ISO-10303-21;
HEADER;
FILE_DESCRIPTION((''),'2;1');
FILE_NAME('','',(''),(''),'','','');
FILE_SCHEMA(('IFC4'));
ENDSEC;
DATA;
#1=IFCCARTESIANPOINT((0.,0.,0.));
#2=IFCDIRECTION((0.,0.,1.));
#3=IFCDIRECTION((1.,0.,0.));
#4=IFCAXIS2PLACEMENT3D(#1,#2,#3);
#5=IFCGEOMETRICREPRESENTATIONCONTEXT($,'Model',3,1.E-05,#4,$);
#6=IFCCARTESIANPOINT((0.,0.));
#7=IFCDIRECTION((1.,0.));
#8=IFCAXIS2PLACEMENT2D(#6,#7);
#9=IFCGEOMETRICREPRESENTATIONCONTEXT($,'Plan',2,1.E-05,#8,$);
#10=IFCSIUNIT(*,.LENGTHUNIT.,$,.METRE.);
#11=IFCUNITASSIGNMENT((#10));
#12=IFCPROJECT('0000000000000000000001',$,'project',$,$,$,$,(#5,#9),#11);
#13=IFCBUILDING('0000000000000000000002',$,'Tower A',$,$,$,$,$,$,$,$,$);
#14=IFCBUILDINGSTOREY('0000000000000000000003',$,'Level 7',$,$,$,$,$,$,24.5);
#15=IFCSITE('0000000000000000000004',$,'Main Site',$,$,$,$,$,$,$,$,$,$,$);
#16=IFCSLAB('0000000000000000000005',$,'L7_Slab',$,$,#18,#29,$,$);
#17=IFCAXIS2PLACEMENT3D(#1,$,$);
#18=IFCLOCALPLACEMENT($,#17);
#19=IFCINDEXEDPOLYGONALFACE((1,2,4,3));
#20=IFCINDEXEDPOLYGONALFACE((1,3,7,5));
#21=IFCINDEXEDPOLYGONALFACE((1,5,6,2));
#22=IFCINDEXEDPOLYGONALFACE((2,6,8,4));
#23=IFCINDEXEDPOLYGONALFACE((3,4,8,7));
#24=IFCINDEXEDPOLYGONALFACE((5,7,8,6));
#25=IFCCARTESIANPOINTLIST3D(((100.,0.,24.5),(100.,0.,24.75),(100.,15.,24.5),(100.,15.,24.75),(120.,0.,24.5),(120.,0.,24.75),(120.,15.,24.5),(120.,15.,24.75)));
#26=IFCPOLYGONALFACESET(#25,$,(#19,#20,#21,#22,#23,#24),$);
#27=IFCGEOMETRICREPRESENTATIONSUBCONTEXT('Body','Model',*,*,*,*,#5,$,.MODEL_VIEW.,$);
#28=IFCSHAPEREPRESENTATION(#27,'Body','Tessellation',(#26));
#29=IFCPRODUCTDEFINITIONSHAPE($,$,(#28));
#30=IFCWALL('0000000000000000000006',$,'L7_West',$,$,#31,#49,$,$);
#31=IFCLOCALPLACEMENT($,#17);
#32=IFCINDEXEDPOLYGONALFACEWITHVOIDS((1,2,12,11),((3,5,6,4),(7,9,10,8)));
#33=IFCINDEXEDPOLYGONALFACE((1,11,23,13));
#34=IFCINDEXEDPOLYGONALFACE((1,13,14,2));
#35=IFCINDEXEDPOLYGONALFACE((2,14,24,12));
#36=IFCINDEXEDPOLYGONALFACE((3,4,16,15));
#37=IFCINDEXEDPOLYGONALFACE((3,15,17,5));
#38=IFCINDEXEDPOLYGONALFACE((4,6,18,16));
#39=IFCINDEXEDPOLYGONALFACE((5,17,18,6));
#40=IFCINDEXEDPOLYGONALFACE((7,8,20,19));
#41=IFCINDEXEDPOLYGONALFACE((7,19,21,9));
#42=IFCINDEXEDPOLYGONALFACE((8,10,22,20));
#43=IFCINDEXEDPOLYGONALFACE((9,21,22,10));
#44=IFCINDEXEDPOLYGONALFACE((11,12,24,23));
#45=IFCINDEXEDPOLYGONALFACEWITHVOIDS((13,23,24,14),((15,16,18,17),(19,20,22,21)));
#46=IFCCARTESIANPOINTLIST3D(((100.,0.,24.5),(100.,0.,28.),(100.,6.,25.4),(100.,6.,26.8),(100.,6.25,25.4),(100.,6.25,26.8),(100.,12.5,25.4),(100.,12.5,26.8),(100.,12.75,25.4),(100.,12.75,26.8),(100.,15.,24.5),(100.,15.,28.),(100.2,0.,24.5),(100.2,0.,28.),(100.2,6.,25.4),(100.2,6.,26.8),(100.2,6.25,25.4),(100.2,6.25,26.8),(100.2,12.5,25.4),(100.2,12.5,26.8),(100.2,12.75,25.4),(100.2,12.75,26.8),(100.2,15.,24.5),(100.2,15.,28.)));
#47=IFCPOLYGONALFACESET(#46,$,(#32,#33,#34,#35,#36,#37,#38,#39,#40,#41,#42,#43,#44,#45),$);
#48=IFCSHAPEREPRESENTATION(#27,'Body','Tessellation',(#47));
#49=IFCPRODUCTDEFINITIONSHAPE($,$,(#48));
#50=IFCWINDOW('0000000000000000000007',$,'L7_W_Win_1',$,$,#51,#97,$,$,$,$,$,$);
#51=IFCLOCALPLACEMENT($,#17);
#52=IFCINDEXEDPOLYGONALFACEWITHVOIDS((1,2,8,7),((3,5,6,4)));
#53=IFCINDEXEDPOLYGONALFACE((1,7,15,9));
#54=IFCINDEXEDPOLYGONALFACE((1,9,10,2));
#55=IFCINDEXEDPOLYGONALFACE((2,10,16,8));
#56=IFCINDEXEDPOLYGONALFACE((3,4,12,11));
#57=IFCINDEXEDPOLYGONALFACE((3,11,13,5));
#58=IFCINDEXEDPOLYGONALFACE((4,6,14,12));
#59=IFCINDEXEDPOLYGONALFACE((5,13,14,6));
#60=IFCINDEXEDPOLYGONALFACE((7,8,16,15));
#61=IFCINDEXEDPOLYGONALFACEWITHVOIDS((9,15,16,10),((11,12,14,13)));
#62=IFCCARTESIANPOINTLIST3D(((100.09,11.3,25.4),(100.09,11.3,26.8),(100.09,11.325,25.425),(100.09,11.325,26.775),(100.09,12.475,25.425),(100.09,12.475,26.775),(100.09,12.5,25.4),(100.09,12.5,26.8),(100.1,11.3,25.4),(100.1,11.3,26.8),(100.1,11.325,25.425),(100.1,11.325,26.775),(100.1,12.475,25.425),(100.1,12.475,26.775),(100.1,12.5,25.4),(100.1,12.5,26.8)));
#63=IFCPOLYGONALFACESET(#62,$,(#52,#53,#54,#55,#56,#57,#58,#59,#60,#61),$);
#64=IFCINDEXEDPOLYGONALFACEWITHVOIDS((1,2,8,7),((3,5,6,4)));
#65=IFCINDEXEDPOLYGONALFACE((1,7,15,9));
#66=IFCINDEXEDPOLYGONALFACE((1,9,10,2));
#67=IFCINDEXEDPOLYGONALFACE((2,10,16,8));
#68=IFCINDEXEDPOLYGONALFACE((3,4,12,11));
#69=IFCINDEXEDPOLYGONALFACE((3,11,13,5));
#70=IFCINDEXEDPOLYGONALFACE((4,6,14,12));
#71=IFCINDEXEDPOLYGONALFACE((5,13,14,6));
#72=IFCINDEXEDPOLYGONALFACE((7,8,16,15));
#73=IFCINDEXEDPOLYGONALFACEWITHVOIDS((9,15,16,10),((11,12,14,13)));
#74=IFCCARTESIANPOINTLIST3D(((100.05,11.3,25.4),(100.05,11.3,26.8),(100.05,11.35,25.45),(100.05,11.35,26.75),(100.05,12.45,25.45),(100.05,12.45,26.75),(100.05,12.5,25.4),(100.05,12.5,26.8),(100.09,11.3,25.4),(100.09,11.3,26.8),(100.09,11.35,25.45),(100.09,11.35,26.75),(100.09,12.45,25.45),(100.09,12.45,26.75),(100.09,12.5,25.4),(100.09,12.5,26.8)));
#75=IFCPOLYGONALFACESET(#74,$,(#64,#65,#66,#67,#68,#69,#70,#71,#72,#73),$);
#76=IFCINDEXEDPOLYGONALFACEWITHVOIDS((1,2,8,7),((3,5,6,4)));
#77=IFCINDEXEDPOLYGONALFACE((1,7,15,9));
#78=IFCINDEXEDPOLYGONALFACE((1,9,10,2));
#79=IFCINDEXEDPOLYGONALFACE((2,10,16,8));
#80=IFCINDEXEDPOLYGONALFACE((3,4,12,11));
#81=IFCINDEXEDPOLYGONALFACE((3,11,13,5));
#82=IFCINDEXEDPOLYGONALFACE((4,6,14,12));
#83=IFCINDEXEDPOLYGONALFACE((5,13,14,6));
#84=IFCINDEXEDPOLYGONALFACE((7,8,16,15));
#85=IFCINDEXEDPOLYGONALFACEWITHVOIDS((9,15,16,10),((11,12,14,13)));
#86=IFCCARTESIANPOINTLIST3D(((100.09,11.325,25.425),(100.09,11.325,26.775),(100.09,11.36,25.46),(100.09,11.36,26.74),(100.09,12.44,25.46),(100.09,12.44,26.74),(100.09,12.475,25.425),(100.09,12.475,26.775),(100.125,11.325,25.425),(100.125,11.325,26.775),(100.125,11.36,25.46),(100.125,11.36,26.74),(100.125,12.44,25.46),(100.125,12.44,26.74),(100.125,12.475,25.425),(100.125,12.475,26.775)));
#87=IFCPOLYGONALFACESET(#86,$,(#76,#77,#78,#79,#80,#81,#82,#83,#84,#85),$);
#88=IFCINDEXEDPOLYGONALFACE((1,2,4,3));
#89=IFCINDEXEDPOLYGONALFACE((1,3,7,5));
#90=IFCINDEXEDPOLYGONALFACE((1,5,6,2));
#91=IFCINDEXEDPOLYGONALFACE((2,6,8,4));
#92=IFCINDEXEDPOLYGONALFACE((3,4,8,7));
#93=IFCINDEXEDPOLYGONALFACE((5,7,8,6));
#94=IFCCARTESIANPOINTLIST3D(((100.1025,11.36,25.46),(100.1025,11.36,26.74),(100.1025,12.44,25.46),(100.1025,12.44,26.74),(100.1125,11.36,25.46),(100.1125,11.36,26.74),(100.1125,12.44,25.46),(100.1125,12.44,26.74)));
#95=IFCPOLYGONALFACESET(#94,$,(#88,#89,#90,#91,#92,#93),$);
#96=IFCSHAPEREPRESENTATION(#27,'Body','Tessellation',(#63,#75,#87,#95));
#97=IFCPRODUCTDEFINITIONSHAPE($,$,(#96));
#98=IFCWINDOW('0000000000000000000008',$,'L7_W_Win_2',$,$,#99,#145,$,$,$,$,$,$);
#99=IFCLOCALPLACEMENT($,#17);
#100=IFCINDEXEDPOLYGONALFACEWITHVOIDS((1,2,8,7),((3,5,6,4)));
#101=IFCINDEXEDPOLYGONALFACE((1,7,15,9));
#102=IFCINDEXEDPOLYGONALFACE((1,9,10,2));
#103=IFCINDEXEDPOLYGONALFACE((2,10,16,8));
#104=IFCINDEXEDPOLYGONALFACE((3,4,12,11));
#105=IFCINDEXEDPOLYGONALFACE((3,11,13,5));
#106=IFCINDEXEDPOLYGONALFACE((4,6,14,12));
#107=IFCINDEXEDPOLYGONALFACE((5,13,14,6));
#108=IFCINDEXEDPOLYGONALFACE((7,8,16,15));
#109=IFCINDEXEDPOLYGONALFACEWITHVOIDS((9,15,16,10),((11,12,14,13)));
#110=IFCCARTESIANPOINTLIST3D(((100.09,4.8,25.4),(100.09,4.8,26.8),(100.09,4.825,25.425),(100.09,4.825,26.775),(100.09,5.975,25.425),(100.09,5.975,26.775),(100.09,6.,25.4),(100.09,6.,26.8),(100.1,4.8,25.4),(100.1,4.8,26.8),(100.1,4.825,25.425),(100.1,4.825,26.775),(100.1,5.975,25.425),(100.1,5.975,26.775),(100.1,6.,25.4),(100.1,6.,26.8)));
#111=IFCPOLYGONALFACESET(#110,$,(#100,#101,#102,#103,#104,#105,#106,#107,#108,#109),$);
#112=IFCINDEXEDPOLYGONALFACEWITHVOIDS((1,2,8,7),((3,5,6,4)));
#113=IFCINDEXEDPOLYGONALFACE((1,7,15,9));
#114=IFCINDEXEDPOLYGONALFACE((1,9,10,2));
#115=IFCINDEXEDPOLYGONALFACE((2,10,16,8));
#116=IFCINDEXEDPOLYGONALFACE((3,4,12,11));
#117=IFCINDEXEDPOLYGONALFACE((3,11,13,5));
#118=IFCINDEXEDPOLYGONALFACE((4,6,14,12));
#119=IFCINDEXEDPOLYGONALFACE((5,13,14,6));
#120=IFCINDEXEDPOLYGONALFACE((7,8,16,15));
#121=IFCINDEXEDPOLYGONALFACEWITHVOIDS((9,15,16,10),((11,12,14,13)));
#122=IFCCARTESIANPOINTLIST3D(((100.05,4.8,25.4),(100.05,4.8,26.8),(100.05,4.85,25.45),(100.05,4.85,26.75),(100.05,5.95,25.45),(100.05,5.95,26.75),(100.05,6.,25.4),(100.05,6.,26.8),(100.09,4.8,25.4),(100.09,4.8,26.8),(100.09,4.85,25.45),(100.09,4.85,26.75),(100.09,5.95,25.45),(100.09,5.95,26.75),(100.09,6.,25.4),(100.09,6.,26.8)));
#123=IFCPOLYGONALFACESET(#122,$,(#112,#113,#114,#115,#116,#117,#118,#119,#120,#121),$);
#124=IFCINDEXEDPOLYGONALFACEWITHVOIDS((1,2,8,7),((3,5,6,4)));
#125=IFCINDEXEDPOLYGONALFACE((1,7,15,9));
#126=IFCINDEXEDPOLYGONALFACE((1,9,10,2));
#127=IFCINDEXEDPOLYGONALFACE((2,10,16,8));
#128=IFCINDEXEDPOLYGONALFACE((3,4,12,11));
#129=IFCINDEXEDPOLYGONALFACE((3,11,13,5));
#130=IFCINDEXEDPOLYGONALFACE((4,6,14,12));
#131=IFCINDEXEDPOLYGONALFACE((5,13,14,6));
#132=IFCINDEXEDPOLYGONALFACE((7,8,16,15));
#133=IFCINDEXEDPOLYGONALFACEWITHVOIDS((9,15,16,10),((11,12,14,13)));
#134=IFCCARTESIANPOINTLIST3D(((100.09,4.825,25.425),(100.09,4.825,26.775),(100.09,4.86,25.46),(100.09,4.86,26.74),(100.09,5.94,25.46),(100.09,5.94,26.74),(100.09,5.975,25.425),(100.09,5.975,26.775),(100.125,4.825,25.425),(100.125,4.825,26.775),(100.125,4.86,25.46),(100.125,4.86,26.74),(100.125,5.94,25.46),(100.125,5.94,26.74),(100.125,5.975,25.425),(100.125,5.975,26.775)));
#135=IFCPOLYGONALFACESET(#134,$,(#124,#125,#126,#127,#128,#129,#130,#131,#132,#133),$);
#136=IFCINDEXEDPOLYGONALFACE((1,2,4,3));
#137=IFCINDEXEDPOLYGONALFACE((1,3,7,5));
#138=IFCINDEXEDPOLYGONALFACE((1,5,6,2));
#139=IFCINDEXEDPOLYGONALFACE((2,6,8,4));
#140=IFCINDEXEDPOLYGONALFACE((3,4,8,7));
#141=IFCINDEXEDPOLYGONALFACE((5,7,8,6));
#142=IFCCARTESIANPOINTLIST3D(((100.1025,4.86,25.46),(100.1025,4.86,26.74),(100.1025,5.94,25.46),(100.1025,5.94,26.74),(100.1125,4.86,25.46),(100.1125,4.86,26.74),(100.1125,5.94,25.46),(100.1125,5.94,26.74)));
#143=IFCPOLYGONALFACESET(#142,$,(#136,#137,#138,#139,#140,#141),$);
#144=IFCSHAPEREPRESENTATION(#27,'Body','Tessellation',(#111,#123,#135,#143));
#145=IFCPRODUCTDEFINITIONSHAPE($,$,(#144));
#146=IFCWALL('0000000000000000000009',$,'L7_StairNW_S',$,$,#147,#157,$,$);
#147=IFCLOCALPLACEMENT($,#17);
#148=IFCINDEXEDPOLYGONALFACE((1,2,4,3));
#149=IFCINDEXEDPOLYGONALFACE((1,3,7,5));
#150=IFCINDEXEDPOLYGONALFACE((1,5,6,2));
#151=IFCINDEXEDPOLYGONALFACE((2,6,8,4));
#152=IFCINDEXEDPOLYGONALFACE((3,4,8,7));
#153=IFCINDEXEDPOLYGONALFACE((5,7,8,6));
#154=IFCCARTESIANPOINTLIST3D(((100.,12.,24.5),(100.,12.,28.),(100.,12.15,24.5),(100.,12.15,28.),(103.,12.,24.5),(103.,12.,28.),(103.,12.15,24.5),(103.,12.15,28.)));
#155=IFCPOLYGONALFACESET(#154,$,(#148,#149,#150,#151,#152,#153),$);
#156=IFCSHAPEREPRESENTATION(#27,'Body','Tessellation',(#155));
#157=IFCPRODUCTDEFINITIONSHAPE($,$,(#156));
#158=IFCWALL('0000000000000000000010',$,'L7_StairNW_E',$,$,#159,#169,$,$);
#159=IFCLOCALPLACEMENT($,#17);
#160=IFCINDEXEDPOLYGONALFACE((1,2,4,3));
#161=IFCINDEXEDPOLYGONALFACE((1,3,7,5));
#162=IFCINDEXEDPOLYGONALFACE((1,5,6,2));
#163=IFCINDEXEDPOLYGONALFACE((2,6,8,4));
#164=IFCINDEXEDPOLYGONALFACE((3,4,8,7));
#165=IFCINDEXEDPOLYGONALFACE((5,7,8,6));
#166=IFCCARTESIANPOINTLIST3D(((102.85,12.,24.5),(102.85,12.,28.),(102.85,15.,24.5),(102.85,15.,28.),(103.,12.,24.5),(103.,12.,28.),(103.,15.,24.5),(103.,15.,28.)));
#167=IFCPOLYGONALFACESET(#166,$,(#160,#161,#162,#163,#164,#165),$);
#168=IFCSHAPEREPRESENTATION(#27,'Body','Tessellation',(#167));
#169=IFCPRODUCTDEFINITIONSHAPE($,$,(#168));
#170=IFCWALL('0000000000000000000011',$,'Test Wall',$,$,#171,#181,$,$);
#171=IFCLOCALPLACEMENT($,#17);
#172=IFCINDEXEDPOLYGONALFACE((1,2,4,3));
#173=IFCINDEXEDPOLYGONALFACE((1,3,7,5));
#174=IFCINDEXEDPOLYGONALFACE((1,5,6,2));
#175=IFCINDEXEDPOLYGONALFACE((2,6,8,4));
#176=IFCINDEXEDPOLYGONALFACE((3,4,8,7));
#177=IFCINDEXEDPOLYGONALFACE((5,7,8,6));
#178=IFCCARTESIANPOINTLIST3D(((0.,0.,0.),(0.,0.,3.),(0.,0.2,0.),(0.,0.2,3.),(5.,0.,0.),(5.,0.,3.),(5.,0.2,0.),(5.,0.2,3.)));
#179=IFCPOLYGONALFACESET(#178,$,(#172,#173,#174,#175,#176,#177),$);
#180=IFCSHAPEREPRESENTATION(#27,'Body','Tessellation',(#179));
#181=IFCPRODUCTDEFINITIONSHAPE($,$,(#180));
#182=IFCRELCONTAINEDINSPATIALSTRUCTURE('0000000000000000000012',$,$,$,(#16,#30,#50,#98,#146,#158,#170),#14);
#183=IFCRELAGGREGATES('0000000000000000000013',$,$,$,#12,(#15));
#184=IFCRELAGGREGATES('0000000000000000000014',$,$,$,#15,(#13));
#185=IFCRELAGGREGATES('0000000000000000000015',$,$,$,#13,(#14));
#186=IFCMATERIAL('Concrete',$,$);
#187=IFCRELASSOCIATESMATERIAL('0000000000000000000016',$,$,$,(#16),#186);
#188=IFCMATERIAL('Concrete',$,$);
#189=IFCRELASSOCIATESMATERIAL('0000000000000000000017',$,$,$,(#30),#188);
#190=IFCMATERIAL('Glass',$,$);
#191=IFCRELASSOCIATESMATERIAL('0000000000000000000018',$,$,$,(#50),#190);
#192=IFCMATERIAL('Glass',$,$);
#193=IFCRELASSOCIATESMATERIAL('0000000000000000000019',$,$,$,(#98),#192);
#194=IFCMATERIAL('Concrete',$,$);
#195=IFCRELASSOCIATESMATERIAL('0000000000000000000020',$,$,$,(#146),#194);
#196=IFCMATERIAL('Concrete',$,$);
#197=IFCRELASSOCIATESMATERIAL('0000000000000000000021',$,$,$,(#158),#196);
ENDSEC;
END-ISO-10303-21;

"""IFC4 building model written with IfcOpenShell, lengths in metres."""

from ifc_helpers import new_model, si_unit, frame, origin_with_axes, origin_2d_with_axis, place, context, subcontext, project, spatial, line, indexed_curve, outline, extrude, material, element, fill, save


model = new_model("IFC4")

# Units and contexts
model_context = context("Model", 3, precision=1e-05, world=origin_with_axes())
plan_context = context("Plan", 2, precision=1e-05, world=origin_2d_with_axis())
body_context = subcontext(model_context, "Body", "Model", "MODEL_VIEW")
ifc_project = project(units=[si_unit("LENGTHUNIT", "METRE")], contexts=[model_context, plan_context])

# Site, building, storey
site = spatial("IfcSite", under=ifc_project, Name="Main Site")
building = spatial("IfcBuilding", under=site, Name="Tower A")
storey = spatial("IfcBuildingStorey", under=building, Name="Level 7", Elevation=24.5)

# Slab
ifc_material_1 = material(Name="Concrete")
slab_placement = place(None, frame((100.0, 0.0, 24.5), z_axis=(0.0, 0.0, 1.0), x_axis=(1.0, 0.0, 0.0)))
element("IfcSlab", 1, at=slab_placement, inside=storey, material=ifc_material_1, Name="L7_Slab", context=body_context, shape_type="SweptSolid", body=[
    extrude(outline(indexed_curve([(0.0, 0.0), (20.0, 0.0), (20.0, 15.0), (0.0, 15.0)])), None, (0.0, 0.0, 1.0), 0.25),
])

# Wall, openings, windows
ifc_material_2 = material(Name="Concrete")
wall_1_placement = place(None, frame((100.0, 15.0, 24.5), z_axis=(0.0, 0.0, 1.0), x_axis=(0.0, -1.0, 0.0)))
wall_1 = element("IfcWall", 2, at=wall_1_placement, inside=storey, material=ifc_material_2, Name="L7_West", context=body_context, shape_type="SweptSolid", body=[
    extrude(outline(indexed_curve([(0.0, 0.0), (0.0, 0.2), (15.0, 0.2), (15.0, 0.0), (0.0, 0.0)], self_intersect=False)), origin_with_axes(), (0.0, 0.0, 1.0), 3.5),
])
opening_1_placement = place(wall_1_placement, frame((2.5, 0.0, 0.9), z_axis=(0.0, 0.0, 1.0), x_axis=(0.0, 1.0, 0.0)))
opening_1 = element("IfcOpeningElement", 3, at=opening_1_placement, cuts=wall_1, context=body_context, shape_type="SweptSolid", body=[
    extrude(outline(indexed_curve([(0.0, 0.0), (0.0, 0.25), (1.2, 0.25), (1.2, 0.0), (0.0, 0.0)], self_intersect=False)), origin_with_axes(), (0.0, 0.0, 1.0), 1.4),
])
opening_2_placement = place(wall_1_placement, frame((9.0, 0.0, 0.9), z_axis=(0.0, 0.0, 1.0), x_axis=(0.0, 1.0, 0.0)))
opening_2 = element("IfcOpeningElement", 4, at=opening_2_placement, cuts=wall_1, context=body_context, shape_type="SweptSolid", body=[
    extrude(outline(indexed_curve([(0.0, 0.0), (0.0, 0.25), (1.2, 0.25), (1.2, 0.0), (0.0, 0.0)], self_intersect=False)), origin_with_axes(), (0.0, 0.0, 1.0), 1.4),
])
ifc_material_3 = material(Name="Glass")
window_1_placement = place(None, frame((100.0, 12.5, 25.4), z_axis=(0.0, 0.0, 1.0), x_axis=(0.0, -1.0, 0.0)))
window_1 = element("IfcWindow", 5, at=window_1_placement, inside=storey, material=ifc_material_3, Name="L7_W_Win_1", context=body_context, shape_type="SweptSolid", body=[
    extrude(outline(indexed_curve([(0.0, 0.0), (1.2, 0.0), (1.2, 1.4), (0.0, 1.4)], segments=[line(1, 2, 3, 4, 1)]), holes=[indexed_curve([(0.025, 0.025), (1.175, 0.025), (1.175, 1.375), (0.025, 1.375)], segments=[line(1, 2, 3, 4, 1)])]), frame((0.0, 0.09, 0.0), z_axis=(0.0, -1.0, 0.0), x_axis=(1.0, 0.0, 0.0)), (0.0, 0.0, -1.0), 0.01),
    extrude(outline(indexed_curve([(0.0, 0.0), (1.2, 0.0), (1.2, 1.4), (0.0, 1.4)], segments=[line(1, 2, 3, 4, 1)]), holes=[indexed_curve([(0.05, 0.05), (1.15, 0.05), (1.15, 1.35), (0.05, 1.35)], segments=[line(1, 2, 3, 4, 1)])]), frame((0.0, 0.05, 0.0), z_axis=(0.0, -1.0, 0.0), x_axis=(1.0, 0.0, 0.0)), (0.0, 0.0, -1.0), 0.04),
    extrude(outline(indexed_curve([(0.0, 0.0), (1.15, 0.0), (1.15, 1.35), (0.0, 1.35)], segments=[line(1, 2, 3, 4, 1)]), holes=[indexed_curve([(0.035, 0.035), (1.115, 0.035), (1.115, 1.315), (0.035, 1.315)], segments=[line(1, 2, 3, 4, 1)])]), frame((0.025, 0.09, 0.025), z_axis=(0.0, -1.0, 0.0), x_axis=(1.0, 0.0, 0.0)), (0.0, 0.0, -1.0), 0.035),
    extrude(outline(indexed_curve([(0.035, 0.035), (1.115, 0.035), (1.115, 1.315), (0.035, 1.315)], segments=[line(1, 2, 3, 4, 1)])), frame((0.025, 0.1025, 0.025), z_axis=(0.0, -1.0, 0.0), x_axis=(1.0, 0.0, 0.0)), (0.0, 0.0, -1.0), 0.01),
])
fill(opening_1, window_1)
ifc_material_4 = material(Name="Glass")
window_2_placement = place(None, frame((100.0, 6.0, 25.4), z_axis=(0.0, 0.0, 1.0), x_axis=(0.0, -1.0, 0.0)))
window_2 = element("IfcWindow", 6, at=window_2_placement, inside=storey, material=ifc_material_4, Name="L7_W_Win_2", context=body_context, shape_type="SweptSolid", body=[
    extrude(outline(indexed_curve([(0.0, 0.0), (1.2, 0.0), (1.2, 1.4), (0.0, 1.4)], segments=[line(1, 2, 3, 4, 1)]), holes=[indexed_curve([(0.025, 0.025), (1.175, 0.025), (1.175, 1.375), (0.025, 1.375)], segments=[line(1, 2, 3, 4, 1)])]), frame((0.0, 0.09, 0.0), z_axis=(0.0, -1.0, 0.0), x_axis=(1.0, 0.0, 0.0)), (0.0, 0.0, -1.0), 0.01),
    extrude(outline(indexed_curve([(0.0, 0.0), (1.2, 0.0), (1.2, 1.4), (0.0, 1.4)], segments=[line(1, 2, 3, 4, 1)]), holes=[indexed_curve([(0.05, 0.05), (1.15, 0.05), (1.15, 1.35), (0.05, 1.35)], segments=[line(1, 2, 3, 4, 1)])]), frame((0.0, 0.05, 0.0), z_axis=(0.0, -1.0, 0.0), x_axis=(1.0, 0.0, 0.0)), (0.0, 0.0, -1.0), 0.04),
    extrude(outline(indexed_curve([(0.0, 0.0), (1.15, 0.0), (1.15, 1.35), (0.0, 1.35)], segments=[line(1, 2, 3, 4, 1)]), holes=[indexed_curve([(0.035, 0.035), (1.115, 0.035), (1.115, 1.315), (0.035, 1.315)], segments=[line(1, 2, 3, 4, 1)])]), frame((0.025, 0.09, 0.025), z_axis=(0.0, -1.0, 0.0), x_axis=(1.0, 0.0, 0.0)), (0.0, 0.0, -1.0), 0.035),
    extrude(outline(indexed_curve([(0.035, 0.035), (1.115, 0.035), (1.115, 1.315), (0.035, 1.315)], segments=[line(1, 2, 3, 4, 1)])), frame((0.025, 0.1025, 0.025), z_axis=(0.0, -1.0, 0.0), x_axis=(1.0, 0.0, 0.0)), (0.0, 0.0, -1.0), 0.01),
])
fill(opening_2, window_2)

# Walls
ifc_material_5 = material(Name="Concrete")
wall_2_placement = place(None, frame((100.0, 12.0, 24.5), z_axis=(0.0, 0.0, 1.0), x_axis=(1.0, 0.0, 0.0)))
element("IfcWall", 7, at=wall_2_placement, inside=storey, material=ifc_material_5, Name="L7_StairNW_S", context=body_context, shape_type="SweptSolid", body=[
    extrude(outline(indexed_curve([(0.0, 0.0), (0.0, 0.15), (3.0, 0.15), (3.0, 0.0), (0.0, 0.0)], self_intersect=False)), origin_with_axes(), (0.0, 0.0, 1.0), 3.5),
])
ifc_material_6 = material(Name="Concrete")
wall_3_placement = place(None, frame((103.0, 12.0, 24.5), z_axis=(0.0, 0.0, 1.0), x_axis=(0.0, 1.0, 0.0)))
element("IfcWall", 8, at=wall_3_placement, inside=storey, material=ifc_material_6, Name="L7_StairNW_E", context=body_context, shape_type="SweptSolid", body=[
    extrude(outline(indexed_curve([(0.0, 0.0), (0.0, 0.15), (3.0, 0.15), (3.0, 0.0), (0.0, 0.0)], self_intersect=False)), origin_with_axes(), (0.0, 0.0, 1.0), 3.5),
])

# Wall
wall_4_placement = place(None, origin_with_axes())
element("IfcWall", 9, at=wall_4_placement, inside=storey, Name="Test Wall", context=body_context, shape_type="SweptSolid", body=[
    extrude(outline(indexed_curve([(0.0, 0.0), (0.0, 0.2), (5.0, 0.2), (5.0, 0.0), (0.0, 0.0)], self_intersect=False)), origin_with_axes(), (0.0, 0.0, 1.0), 3.0),
])

save(model, "model.ifc")
